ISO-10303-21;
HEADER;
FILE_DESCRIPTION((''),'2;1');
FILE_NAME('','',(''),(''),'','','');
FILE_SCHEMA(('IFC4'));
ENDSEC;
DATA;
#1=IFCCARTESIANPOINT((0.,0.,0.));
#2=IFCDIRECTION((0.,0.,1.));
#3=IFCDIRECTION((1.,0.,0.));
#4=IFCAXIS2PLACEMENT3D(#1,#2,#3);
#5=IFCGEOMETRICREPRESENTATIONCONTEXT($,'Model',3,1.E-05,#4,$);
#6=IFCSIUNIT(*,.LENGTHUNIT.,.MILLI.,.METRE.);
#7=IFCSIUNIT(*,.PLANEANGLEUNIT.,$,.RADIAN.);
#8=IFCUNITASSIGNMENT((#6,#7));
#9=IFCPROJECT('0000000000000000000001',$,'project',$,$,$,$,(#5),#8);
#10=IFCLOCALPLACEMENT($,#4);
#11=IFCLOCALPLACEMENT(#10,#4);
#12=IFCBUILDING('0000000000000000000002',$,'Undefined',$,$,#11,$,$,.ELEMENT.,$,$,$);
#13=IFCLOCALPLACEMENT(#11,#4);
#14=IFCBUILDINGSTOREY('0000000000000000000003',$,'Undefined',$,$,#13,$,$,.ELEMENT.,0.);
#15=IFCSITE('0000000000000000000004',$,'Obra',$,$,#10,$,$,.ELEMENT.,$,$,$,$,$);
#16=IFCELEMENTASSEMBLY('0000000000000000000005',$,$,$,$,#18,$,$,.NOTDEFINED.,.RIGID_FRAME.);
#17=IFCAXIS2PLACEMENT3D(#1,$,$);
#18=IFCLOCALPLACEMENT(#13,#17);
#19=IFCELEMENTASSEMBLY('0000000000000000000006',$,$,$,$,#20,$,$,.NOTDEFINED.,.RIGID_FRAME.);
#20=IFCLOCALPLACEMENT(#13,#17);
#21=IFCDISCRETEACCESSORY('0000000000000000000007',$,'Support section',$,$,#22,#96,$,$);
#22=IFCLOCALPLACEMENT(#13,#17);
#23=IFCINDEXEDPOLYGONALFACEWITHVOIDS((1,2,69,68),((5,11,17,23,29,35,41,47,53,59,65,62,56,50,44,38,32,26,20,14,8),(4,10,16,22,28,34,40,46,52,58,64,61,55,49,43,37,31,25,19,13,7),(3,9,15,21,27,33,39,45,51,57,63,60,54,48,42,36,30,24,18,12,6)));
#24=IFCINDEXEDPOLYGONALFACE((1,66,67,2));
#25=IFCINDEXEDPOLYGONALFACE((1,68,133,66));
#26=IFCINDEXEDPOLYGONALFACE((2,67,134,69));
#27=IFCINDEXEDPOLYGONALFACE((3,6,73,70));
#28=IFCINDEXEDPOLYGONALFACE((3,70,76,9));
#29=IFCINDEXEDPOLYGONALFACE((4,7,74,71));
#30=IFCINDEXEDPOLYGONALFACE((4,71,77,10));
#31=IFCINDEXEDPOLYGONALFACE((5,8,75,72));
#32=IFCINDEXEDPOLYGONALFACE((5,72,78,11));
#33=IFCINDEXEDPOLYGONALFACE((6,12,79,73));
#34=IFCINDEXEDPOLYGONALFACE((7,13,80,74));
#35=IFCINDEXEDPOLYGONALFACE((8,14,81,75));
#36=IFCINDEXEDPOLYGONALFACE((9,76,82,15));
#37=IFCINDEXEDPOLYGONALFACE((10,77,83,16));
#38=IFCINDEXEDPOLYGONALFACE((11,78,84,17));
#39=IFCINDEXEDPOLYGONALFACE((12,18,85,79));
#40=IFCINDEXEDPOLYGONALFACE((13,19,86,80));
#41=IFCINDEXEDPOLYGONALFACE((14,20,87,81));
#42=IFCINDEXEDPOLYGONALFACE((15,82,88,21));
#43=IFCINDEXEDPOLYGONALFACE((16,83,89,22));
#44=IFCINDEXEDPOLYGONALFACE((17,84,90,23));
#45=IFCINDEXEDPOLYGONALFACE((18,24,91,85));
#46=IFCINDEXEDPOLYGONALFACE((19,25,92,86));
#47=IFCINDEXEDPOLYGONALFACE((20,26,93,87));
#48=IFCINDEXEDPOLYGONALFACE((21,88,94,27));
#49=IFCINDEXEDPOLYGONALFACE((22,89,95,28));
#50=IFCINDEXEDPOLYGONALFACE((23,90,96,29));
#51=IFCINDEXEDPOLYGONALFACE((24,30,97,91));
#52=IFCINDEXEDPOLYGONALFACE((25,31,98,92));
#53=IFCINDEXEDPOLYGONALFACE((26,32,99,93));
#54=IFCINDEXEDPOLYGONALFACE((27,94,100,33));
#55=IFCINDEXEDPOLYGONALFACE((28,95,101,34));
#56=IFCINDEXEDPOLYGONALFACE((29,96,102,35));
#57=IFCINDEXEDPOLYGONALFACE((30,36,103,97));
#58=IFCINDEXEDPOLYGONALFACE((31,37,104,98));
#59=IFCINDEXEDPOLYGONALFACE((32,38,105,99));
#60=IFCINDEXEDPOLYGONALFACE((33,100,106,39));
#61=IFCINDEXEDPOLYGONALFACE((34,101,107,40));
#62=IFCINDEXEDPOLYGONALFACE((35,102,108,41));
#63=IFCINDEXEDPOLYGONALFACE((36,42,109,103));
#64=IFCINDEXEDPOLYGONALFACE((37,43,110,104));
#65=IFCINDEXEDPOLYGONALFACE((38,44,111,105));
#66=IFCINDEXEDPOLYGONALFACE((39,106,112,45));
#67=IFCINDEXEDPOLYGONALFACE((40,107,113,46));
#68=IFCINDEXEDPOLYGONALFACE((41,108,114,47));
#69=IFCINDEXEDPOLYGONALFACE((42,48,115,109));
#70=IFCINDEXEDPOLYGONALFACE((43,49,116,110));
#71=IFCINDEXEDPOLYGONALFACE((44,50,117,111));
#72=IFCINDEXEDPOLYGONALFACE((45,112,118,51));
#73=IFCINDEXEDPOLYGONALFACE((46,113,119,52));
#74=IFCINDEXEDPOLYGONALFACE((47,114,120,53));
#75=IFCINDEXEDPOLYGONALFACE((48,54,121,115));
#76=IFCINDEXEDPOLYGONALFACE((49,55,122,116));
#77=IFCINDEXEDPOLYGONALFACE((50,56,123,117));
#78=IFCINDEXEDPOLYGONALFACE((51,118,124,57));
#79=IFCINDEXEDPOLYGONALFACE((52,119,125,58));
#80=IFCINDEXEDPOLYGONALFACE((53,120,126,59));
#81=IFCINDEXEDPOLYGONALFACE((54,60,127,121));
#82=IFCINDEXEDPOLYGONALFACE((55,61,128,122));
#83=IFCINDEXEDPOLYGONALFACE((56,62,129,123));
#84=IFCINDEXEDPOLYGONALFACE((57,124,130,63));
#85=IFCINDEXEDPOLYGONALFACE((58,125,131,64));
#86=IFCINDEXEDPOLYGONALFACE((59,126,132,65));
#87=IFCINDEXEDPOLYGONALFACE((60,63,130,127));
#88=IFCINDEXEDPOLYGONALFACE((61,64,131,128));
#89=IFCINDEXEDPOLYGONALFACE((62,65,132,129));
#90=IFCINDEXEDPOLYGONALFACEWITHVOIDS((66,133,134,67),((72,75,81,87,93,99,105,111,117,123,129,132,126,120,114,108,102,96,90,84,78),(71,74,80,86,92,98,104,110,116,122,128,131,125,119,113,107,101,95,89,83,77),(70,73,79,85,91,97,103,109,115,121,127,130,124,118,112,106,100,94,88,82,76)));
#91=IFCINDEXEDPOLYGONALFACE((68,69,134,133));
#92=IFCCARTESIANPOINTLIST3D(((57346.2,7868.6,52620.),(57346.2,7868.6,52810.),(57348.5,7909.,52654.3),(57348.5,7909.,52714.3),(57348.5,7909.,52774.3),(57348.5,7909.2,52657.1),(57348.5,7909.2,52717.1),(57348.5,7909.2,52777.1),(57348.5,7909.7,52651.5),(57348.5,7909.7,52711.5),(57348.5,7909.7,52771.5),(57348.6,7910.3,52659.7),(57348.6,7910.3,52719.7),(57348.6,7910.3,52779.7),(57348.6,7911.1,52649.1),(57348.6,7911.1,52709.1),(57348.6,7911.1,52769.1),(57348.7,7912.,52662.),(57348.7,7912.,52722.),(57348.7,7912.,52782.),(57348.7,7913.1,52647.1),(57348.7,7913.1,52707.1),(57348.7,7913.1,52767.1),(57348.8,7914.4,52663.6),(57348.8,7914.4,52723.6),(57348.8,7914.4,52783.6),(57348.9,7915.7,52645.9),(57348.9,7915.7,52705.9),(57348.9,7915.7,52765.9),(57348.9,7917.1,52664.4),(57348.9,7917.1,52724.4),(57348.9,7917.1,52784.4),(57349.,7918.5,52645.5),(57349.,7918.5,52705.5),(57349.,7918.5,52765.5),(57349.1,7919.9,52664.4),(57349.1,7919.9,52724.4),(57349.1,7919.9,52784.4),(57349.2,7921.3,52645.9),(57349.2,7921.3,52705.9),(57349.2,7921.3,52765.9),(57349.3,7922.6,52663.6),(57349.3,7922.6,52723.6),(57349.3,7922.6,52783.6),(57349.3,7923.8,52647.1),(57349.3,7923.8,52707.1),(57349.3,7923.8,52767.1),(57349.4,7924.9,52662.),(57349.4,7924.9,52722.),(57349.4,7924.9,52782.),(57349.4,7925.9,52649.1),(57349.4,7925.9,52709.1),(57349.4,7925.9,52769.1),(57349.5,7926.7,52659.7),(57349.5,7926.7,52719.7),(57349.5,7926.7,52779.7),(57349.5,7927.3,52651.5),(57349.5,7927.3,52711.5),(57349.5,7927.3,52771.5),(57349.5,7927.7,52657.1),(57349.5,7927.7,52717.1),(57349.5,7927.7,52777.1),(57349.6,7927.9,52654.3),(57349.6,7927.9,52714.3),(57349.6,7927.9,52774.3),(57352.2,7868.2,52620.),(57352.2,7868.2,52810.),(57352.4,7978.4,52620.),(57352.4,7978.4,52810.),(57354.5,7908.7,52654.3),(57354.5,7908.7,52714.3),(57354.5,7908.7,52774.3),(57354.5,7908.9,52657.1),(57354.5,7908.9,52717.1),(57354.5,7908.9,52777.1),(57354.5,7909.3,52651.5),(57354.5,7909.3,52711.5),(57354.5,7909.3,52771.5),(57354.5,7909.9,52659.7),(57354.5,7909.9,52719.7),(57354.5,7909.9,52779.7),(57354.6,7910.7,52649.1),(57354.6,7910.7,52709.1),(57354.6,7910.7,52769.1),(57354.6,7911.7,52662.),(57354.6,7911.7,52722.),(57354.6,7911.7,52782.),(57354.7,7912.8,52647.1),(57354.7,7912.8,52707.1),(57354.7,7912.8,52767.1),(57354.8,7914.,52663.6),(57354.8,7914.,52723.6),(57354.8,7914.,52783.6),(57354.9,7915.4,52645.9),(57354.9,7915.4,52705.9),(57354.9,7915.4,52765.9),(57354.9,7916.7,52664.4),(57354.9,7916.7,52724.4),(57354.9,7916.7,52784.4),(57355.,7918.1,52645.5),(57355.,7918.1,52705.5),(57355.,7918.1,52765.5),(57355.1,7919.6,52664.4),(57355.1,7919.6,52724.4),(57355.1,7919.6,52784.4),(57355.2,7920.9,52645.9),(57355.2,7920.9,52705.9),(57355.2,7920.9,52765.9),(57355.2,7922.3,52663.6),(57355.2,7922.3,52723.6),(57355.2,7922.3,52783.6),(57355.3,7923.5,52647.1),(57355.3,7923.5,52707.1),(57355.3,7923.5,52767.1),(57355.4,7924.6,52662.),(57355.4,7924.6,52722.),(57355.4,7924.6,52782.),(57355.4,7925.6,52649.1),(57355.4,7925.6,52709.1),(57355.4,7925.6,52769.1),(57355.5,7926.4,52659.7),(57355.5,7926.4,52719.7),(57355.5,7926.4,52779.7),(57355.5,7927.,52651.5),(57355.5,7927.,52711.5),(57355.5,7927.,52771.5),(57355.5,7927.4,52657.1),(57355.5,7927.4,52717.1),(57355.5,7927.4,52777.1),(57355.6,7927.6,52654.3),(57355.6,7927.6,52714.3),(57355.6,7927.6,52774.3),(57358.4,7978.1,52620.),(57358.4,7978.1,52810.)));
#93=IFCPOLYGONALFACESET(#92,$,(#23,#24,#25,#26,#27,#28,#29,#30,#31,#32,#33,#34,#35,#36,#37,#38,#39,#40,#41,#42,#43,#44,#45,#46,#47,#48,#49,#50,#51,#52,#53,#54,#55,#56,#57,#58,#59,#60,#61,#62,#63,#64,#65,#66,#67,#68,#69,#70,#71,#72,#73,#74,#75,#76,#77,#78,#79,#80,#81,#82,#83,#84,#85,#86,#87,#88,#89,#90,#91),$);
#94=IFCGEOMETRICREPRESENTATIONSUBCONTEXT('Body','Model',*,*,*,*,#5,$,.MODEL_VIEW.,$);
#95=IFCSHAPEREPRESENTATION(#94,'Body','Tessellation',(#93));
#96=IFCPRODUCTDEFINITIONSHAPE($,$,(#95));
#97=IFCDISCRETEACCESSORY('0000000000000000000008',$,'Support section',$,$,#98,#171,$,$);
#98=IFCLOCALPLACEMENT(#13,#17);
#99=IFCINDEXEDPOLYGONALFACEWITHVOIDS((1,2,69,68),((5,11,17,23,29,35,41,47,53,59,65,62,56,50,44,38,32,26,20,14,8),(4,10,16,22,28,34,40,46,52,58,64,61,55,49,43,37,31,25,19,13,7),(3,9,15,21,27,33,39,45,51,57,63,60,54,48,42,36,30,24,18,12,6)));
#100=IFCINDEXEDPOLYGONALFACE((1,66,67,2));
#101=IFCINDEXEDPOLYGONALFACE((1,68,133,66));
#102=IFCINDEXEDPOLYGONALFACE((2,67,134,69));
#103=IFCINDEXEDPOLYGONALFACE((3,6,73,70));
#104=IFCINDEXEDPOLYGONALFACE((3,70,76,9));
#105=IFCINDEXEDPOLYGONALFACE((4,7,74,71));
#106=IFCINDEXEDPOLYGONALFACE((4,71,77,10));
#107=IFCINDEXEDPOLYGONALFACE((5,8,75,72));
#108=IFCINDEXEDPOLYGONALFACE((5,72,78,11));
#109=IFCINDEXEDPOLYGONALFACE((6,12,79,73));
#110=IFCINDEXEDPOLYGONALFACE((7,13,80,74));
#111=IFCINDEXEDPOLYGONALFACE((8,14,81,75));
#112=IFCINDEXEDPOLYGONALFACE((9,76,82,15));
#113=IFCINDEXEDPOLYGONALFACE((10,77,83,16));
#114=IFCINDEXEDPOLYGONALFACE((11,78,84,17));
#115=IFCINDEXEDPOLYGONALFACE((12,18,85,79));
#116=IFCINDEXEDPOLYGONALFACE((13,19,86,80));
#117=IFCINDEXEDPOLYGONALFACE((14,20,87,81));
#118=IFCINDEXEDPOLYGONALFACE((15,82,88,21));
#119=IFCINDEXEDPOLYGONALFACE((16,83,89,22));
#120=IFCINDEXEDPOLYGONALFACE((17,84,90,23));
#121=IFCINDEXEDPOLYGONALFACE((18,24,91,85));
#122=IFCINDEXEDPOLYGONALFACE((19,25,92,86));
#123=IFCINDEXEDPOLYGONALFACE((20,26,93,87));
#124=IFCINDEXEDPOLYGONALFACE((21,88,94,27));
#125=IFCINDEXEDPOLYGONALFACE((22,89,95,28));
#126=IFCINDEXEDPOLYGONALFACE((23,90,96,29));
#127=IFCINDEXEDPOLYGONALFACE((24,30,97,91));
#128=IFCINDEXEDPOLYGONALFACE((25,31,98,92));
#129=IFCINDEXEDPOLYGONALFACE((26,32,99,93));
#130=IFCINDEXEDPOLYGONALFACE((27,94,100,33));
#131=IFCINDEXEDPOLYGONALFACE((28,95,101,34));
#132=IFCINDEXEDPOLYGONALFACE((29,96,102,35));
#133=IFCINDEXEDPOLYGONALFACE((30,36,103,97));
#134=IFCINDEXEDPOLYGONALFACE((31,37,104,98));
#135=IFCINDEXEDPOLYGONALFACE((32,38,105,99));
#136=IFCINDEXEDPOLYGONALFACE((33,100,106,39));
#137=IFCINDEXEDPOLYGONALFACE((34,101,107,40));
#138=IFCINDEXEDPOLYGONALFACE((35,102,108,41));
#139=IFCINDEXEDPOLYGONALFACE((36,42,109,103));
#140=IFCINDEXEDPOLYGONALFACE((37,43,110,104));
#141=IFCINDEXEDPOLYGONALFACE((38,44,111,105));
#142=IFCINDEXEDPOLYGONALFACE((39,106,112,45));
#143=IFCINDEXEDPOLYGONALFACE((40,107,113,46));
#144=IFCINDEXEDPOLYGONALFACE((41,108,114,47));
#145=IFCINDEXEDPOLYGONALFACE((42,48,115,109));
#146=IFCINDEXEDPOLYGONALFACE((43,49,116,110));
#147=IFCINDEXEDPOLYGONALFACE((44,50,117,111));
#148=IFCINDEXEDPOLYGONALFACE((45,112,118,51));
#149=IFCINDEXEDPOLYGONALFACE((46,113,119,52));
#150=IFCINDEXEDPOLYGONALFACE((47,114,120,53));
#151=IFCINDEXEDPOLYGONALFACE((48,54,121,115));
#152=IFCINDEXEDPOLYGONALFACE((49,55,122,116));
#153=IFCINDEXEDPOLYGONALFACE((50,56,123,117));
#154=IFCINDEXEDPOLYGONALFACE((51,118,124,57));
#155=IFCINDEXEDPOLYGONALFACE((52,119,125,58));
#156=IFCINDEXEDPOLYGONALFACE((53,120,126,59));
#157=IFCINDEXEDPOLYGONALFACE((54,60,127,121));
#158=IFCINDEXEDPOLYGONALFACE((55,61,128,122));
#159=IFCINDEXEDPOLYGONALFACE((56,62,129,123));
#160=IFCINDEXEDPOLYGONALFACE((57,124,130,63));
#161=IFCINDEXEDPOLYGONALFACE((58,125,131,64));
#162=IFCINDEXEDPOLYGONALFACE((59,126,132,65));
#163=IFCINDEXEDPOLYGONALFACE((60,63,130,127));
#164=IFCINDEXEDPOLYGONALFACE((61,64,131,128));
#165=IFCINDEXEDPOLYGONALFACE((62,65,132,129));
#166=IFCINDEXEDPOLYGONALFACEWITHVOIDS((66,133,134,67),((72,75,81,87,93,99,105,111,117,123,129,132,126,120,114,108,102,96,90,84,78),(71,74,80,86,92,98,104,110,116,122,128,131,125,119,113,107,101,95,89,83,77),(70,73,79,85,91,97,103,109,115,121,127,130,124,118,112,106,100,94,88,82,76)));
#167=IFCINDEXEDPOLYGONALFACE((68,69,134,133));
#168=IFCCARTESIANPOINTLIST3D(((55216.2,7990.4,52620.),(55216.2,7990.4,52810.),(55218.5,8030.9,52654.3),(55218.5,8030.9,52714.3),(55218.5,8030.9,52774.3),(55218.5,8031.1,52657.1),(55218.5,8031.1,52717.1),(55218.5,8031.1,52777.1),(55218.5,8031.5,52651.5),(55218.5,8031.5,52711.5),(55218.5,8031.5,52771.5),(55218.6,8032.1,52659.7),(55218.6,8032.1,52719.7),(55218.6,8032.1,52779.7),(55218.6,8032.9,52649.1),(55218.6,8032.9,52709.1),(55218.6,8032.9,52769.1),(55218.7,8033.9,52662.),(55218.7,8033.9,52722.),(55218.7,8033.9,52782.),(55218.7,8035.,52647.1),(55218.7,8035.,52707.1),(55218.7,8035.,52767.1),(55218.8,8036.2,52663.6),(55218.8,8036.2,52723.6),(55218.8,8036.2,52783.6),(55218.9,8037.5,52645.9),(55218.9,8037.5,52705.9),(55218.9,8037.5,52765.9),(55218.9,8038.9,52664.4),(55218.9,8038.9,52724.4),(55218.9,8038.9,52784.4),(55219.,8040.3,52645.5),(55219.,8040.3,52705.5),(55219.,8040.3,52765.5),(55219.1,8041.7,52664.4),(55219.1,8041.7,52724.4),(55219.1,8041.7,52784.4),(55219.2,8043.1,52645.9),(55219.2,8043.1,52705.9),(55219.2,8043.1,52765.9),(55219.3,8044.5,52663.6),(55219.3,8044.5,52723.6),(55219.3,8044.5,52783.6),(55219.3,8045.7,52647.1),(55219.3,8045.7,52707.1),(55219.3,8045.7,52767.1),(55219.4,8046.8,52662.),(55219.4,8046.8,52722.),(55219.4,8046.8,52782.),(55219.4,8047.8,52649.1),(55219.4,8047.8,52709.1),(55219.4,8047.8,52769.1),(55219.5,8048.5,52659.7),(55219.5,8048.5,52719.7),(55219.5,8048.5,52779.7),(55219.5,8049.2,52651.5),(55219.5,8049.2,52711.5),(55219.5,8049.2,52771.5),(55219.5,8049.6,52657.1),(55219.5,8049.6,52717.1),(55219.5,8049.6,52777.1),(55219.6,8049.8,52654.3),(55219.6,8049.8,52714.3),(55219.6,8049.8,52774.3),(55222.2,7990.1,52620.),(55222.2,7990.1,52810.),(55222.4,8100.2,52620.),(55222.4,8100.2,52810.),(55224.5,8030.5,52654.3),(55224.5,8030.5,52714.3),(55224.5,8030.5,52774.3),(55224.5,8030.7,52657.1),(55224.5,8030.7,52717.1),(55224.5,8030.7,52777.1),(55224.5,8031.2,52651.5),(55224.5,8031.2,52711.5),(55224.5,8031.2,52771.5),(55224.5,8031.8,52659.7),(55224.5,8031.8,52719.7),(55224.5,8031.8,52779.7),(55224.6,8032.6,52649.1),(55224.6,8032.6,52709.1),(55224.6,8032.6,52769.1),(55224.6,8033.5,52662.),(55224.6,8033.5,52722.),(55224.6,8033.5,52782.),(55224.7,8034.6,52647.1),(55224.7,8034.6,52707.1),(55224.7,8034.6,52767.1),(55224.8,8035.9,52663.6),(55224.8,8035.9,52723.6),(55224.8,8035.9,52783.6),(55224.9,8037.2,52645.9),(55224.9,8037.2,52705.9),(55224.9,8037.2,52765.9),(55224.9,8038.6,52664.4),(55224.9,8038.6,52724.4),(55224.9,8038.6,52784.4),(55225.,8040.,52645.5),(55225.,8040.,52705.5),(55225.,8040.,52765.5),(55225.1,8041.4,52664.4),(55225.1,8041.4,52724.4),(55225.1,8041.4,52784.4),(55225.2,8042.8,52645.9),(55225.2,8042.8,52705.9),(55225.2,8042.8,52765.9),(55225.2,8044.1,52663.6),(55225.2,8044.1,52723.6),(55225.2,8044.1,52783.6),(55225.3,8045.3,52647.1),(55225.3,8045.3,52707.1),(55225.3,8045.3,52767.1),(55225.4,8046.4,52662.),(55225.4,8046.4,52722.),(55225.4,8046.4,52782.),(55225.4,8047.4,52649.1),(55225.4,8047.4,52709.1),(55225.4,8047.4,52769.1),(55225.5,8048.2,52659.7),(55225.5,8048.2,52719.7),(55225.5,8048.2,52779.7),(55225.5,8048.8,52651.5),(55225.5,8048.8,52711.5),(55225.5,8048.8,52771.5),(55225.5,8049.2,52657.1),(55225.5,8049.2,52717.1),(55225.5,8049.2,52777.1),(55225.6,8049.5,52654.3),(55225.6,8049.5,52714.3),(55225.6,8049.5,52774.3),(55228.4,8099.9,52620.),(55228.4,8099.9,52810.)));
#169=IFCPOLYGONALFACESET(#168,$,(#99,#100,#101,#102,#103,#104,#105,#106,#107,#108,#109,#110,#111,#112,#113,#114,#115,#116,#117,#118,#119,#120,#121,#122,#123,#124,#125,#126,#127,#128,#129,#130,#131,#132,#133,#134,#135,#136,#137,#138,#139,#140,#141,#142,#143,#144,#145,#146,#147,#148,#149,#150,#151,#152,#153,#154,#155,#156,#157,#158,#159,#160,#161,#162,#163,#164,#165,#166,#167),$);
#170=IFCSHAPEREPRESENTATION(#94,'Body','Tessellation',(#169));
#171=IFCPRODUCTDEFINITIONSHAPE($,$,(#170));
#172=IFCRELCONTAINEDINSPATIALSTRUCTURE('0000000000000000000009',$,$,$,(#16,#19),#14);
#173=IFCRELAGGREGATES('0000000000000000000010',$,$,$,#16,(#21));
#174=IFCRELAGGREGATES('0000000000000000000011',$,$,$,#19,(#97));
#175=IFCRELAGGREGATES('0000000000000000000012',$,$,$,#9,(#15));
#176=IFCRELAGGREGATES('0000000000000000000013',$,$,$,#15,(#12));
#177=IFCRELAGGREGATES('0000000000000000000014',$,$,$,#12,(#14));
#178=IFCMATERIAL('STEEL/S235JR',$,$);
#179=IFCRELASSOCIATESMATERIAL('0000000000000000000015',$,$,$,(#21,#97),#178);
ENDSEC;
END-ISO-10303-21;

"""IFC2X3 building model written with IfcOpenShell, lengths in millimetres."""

from ifc_helpers import new_model, si_unit, frame, origin_with_axes, origin_2d_with_axis, place, context, subcontext, project, spatial, rectangle, circle, extrude, source, transform, mapped, material, element, aggregate, save


model = new_model("IFC2X3")

# Units and contexts
model_context = context("Model", 3, precision=1e-05, world=origin_with_axes())
body_context = subcontext(model_context, "Body", "Model", "MODEL_VIEW")
ifc_project = project(units=[si_unit("LENGTHUNIT", "METRE", prefix="MILLI"), si_unit("PLANEANGLEUNIT", "RADIAN")], contexts=[model_context])

# Site, building, storey
site_placement = place(None, origin_with_axes())
site = spatial("IfcSite", under=ifc_project, at=site_placement, Name="Obra", CompositionType="ELEMENT")
building_placement = place(site_placement, origin_with_axes())
building = spatial("IfcBuilding", under=site, at=building_placement, Name="Undefined", CompositionType="ELEMENT")
storey_placement = place(building_placement, origin_with_axes())
storey = spatial("IfcBuildingStorey", under=building, at=storey_placement, Name="Undefined", CompositionType="ELEMENT", Elevation=0.0)

# Element assemblies
assembly_1_placement = place(storey_placement, origin_with_axes())
assembly_1 = element("IfcElementAssembly", 1, at=assembly_1_placement, inside=storey, AssemblyPlace="NOTDEFINED", PredefinedType="RIGID_FRAME")
ifc_material_1 = material(Name="STEEL/S235JR")
assembly_2_placement = place(storey_placement, origin_with_axes())
assembly_2 = element("IfcElementAssembly", 2, at=assembly_2_placement, inside=storey, AssemblyPlace="NOTDEFINED", PredefinedType="RIGID_FRAME")

# Discrete accessories, openings
discrete_accessory_1_placement = place(assembly_1_placement, frame((57352.3, 7923.3, 52620.0), z_axis=(0.0, 0.0, 1.0), x_axis=(0.05711, 0.998368, 0.0)))
discrete_accessory_1 = element("IfcDiscreteAccessory", 3, at=discrete_accessory_1_placement, material=ifc_material_1, Name="Support section", context=body_context, shape_type="SweptSolid", body=[
    extrude(rectangle(XDim=6.0, YDim=110.0, at=origin_2d_with_axis()), frame((0.0, 0.0, 190.0), z_axis=(0.0, 0.0, -1.0), x_axis=(0.0, 1.0, 0.0)), (0.0, 0.0, 1.0), 190.0),
])
shared_shape_1 = source(origin_with_axes(), body_context, "Body", "SweptSolid", [
    extrude(circle(Radius=9.5, at=origin_2d_with_axis()), frame((0.0, -9.2, 0.0), z_axis=(0.0, 1.0, 0.0), x_axis=(1.0, 0.0, 0.0)), (0.0, 0.0, 1.0), 6.2),
])
opening_1_placement = place(assembly_1_placement, frame((57361.0, 7967.9, 52835.0), z_axis=(-0.05711, -0.998368, 0.0), x_axis=(0.0, 0.0, -1.0)))
element("IfcOpeningElement", 4, at=opening_1_placement, cuts=discrete_accessory_1, ObjectType="Opening", context=body_context, shape_type="MappedRepresentation", body=[
    mapped(shared_shape_1, transform((60.0, 0.0, 50.0))),
    mapped(shared_shape_1, transform((120.0, 0.0, 50.0))),
    mapped(shared_shape_1, transform((180.0, 0.0, 50.0))),
])
aggregate(assembly_1, [discrete_accessory_1])
discrete_accessory_2_placement = place(assembly_2_placement, frame((55222.3, 8045.2, 52620.0), z_axis=(0.0, 0.0, 1.0), x_axis=(0.05711, 0.998368, 0.0)))
discrete_accessory_2 = element("IfcDiscreteAccessory", 5, at=discrete_accessory_2_placement, material=ifc_material_1, Name="Support section", context=body_context, shape_type="SweptSolid", body=[
    extrude(rectangle(XDim=6.0, YDim=110.0, at=origin_2d_with_axis()), frame((0.0, 0.0, 190.0), z_axis=(0.0, 0.0, -1.0), x_axis=(0.0, 1.0, 0.0)), (0.0, 0.0, 1.0), 190.0),
])
opening_2_placement = place(assembly_2_placement, frame((55231.0, 8089.7, 52835.0), z_axis=(-0.05711, -0.998368, 0.0), x_axis=(0.0, 0.0, -1.0)))
element("IfcOpeningElement", 6, at=opening_2_placement, cuts=discrete_accessory_2, ObjectType="Opening", context=body_context, shape_type="MappedRepresentation", body=[
    mapped(shared_shape_1, transform((60.0, 0.0, 50.0))),
    mapped(shared_shape_1, transform((120.0, 0.0, 50.0))),
    mapped(shared_shape_1, transform((180.0, 0.0, 50.0))),
])
aggregate(assembly_2, [discrete_accessory_2])

save(model, "model.ifc")
